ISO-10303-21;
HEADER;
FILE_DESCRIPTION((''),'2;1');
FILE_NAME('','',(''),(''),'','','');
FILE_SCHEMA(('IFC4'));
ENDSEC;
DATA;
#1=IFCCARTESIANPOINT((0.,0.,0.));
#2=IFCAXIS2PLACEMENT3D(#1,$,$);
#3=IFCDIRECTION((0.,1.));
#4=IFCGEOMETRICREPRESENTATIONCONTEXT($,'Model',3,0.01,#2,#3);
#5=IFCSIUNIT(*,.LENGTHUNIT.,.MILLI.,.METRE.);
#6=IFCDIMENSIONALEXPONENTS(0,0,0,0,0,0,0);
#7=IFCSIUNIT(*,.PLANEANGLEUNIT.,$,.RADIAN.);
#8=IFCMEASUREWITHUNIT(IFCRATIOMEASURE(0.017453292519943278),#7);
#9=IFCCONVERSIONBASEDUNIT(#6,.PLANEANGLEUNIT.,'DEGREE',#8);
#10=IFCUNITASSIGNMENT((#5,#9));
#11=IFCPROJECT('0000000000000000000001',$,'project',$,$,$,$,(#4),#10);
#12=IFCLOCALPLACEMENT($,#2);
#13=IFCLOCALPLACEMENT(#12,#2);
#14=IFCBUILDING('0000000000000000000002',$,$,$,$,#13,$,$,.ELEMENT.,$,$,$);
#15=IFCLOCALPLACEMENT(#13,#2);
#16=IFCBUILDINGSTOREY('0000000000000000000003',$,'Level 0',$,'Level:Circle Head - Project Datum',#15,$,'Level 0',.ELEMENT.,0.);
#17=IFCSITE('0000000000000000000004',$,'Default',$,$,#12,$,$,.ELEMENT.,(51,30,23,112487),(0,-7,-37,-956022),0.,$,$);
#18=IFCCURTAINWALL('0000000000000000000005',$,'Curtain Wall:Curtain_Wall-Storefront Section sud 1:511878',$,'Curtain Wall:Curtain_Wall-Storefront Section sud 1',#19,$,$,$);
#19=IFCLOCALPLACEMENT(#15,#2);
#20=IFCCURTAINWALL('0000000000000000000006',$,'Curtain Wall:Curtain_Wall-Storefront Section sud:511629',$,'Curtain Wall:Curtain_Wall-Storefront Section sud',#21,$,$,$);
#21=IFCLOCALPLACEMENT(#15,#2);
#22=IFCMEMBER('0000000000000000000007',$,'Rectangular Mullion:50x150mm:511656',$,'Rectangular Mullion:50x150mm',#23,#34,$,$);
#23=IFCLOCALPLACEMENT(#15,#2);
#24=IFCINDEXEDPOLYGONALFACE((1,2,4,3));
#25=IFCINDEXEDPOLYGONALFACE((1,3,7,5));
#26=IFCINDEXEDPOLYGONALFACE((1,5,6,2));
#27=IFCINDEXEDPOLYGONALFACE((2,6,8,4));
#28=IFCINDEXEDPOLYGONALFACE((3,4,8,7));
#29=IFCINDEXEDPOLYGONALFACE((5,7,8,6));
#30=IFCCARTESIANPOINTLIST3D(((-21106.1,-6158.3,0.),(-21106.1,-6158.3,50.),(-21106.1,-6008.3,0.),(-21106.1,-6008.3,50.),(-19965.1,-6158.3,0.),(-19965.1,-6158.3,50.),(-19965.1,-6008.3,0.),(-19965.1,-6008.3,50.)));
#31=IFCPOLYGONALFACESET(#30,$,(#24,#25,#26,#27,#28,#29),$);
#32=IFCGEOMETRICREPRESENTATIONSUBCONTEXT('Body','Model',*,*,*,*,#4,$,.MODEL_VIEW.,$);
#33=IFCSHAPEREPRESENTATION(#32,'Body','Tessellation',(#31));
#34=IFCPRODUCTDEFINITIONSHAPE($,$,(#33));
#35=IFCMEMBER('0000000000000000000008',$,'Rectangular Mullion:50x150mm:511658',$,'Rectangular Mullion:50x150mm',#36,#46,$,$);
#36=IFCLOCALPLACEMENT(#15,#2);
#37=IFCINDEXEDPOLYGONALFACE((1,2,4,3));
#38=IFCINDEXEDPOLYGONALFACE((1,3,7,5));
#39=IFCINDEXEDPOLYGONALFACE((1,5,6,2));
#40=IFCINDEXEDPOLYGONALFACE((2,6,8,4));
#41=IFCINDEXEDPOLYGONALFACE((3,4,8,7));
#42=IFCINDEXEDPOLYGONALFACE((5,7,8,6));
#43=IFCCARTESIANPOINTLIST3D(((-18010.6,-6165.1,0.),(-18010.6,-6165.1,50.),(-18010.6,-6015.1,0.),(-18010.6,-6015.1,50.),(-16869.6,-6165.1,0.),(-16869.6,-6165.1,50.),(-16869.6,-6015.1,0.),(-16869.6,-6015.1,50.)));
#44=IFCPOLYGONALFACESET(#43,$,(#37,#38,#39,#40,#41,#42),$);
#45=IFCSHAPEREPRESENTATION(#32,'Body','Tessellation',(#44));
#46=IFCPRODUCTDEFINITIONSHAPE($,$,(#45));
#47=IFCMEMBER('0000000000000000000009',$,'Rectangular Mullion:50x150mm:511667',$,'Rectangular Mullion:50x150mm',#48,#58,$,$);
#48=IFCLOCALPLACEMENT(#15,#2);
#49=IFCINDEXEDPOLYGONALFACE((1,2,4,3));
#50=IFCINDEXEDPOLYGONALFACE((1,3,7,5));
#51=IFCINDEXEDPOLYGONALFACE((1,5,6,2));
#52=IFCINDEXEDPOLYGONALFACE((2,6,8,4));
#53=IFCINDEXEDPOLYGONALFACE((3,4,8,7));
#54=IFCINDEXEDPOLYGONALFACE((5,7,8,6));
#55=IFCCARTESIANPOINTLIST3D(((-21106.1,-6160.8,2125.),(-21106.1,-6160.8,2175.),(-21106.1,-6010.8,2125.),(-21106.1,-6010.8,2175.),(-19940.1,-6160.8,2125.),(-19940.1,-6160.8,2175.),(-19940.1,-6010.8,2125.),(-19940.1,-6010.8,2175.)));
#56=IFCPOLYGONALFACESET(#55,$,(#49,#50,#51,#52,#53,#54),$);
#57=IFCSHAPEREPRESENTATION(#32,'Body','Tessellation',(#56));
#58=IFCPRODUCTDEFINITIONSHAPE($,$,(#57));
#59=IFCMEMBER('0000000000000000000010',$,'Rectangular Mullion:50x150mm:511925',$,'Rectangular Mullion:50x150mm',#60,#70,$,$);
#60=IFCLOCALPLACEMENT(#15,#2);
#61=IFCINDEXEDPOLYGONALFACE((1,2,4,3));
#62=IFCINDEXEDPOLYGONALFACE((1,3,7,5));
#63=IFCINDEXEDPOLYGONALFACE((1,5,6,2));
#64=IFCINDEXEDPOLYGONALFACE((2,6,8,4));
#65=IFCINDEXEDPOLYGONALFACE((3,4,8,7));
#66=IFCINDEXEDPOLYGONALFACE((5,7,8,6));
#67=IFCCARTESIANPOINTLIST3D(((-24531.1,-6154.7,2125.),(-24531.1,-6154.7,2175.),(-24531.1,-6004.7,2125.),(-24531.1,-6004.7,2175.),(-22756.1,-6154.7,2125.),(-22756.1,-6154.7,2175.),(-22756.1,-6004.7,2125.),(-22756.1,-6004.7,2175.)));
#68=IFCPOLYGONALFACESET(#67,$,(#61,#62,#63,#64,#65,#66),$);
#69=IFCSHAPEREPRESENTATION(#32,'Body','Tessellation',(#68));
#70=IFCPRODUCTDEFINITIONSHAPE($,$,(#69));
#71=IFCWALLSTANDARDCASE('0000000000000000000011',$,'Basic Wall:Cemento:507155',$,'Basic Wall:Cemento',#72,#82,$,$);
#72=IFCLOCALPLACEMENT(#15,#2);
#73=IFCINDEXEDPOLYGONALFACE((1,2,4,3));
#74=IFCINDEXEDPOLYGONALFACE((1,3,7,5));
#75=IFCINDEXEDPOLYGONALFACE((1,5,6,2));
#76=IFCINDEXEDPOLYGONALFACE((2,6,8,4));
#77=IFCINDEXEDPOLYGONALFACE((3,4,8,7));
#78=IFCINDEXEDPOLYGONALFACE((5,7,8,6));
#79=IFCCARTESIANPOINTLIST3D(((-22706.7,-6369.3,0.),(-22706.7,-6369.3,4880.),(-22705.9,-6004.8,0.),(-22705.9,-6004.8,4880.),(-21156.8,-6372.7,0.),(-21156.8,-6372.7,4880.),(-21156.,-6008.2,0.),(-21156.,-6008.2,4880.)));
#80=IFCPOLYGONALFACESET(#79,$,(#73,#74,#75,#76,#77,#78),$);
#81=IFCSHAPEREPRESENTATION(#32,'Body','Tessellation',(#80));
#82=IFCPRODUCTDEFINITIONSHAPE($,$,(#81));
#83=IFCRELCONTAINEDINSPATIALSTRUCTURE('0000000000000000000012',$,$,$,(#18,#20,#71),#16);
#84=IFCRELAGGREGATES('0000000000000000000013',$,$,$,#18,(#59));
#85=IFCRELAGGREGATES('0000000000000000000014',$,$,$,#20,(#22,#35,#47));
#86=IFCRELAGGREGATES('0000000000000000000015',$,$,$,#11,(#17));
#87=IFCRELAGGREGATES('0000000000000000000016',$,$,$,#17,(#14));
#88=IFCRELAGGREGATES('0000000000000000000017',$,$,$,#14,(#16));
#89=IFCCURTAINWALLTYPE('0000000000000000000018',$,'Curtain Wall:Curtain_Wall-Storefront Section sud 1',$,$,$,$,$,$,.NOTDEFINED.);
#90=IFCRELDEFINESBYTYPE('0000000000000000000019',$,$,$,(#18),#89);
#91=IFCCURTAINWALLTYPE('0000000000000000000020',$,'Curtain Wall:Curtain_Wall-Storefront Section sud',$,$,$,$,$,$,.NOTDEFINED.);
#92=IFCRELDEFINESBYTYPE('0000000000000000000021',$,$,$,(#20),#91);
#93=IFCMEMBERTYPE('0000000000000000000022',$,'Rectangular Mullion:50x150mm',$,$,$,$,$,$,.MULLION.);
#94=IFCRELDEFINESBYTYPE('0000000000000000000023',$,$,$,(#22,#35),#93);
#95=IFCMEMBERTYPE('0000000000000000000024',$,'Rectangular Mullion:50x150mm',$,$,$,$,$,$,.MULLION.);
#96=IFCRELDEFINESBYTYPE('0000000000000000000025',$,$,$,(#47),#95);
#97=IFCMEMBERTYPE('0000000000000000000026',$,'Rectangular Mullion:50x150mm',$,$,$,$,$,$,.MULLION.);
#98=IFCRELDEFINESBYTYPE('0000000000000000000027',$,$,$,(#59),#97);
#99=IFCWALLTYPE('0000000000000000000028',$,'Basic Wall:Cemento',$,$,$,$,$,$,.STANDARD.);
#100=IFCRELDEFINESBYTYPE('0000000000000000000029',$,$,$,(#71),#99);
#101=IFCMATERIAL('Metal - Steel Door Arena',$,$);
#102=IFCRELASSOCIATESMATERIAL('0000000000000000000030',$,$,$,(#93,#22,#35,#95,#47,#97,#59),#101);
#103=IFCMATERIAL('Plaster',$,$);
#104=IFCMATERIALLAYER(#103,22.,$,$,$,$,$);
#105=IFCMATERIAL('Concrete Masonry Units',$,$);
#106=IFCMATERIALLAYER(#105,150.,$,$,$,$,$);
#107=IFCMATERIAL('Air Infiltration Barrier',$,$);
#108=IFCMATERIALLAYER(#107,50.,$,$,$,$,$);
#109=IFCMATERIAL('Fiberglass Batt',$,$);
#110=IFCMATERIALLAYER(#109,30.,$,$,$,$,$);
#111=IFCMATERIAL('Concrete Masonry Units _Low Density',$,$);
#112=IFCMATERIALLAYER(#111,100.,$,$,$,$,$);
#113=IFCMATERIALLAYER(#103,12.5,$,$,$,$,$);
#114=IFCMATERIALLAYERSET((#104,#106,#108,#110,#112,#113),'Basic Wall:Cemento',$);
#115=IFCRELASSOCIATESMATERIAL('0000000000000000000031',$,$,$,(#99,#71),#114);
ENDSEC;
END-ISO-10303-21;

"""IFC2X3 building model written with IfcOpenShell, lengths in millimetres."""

from ifc_helpers import new_model, entity, si_unit, converted_unit, direction, frame, frame_2d, origin, origin_2d_with_axis, place, context, subcontext, project, spatial, rectangle, extrude, source, transform, mapped, material, layer, layer_set, layer_usage, type_object, type_shapes, element, aggregate, save


model = new_model("IFC2X3")

# Units and contexts
model_context = context("Model", 3, precision=0.01, world=origin(), true_north=direction((0.0, 1.0)))
body_context = subcontext(model_context, "Body", "Model", "MODEL_VIEW")
ifc_project = project(units=[si_unit("LENGTHUNIT", "METRE", prefix="MILLI"), converted_unit("PLANEANGLEUNIT", "DEGREE", entity("IfcRatioMeasure", 0.017453292519943278), si_unit("PLANEANGLEUNIT", "RADIAN"), dimensions=[0, 0, 0, 0, 0, 0, 0])], contexts=[model_context])

# Site, building, storey
site_placement = place(None, origin())
site = spatial("IfcSite", under=ifc_project, at=site_placement, Name="Default", CompositionType="ELEMENT", RefLatitude=(51, 30, 23, 112487), RefLongitude=(0, -7, -37, -956022), RefElevation=0.0)
building_placement = place(site_placement, origin())
building = spatial("IfcBuilding", under=site, at=building_placement, CompositionType="ELEMENT")
storey_placement = place(building_placement, origin())
storey = spatial("IfcBuildingStorey", under=building, at=storey_placement, Name="Level 0", ObjectType="Level:Circle Head - Project Datum", LongName="Level 0", CompositionType="ELEMENT", Elevation=0.0)

# Curtain wall
curtain_wall_type_1 = type_object("IfcCurtainWallType", Name="Curtain Wall:Curtain_Wall-Storefront Section sud 1", PredefinedType="NOTDEFINED")
curtain_wall_1_placement = place(storey_placement, origin())
curtain_wall_1 = element("IfcCurtainWall", 1, at=curtain_wall_1_placement, inside=storey, type_object=curtain_wall_type_1, Name="Curtain Wall:Curtain_Wall-Storefront Section sud 1:511878", ObjectType="Curtain Wall:Curtain_Wall-Storefront Section sud 1")
ifc_material_1 = material(Name="Metal - Steel Door Arena")

# Curtain wall
curtain_wall_type_2 = type_object("IfcCurtainWallType", Name="Curtain Wall:Curtain_Wall-Storefront Section sud", PredefinedType="NOTDEFINED")
curtain_wall_2_placement = place(storey_placement, origin())
curtain_wall_2 = element("IfcCurtainWall", 2, at=curtain_wall_2_placement, inside=storey, type_object=curtain_wall_type_2, Name="Curtain Wall:Curtain_Wall-Storefront Section sud:511629", ObjectType="Curtain Wall:Curtain_Wall-Storefront Section sud")

# Members
member_type_1 = type_object("IfcMemberType", Name="Rectangular Mullion:50x150mm", PredefinedType="MULLION", material=ifc_material_1)
shared_shape_1 = source(origin(), body_context, "Body", "SweptSolid", [
    extrude(rectangle(XDim=150.0, YDim=50.0, at=origin_2d_with_axis()), frame((-25.0, 0.0, -1141.0), z_axis=(0.0, 0.0, 1.0), x_axis=(0.0, -1.0, 0.0)), (0.0, 0.0, 1.0), 1141.0),
])
type_shapes(member_type_1, [shared_shape_1])
member_1_placement = place(curtain_wall_2_placement, frame((-21106.1, -6083.3, 0.0), z_axis=(-1.0, 0.0, 0.0), x_axis=(0.0, 0.0, -1.0)))
member_1 = element("IfcMember", 3, at=member_1_placement, type_object=member_type_1, material=ifc_material_1, Name="Rectangular Mullion:50x150mm:511656", ObjectType="Rectangular Mullion:50x150mm", context=body_context, shape_type="MappedRepresentation", body=[
    mapped(shared_shape_1, transform((0.0, 0.0, 0.0), scale=1.0)),
])
member_2_placement = place(curtain_wall_2_placement, frame((-18010.6, -6090.1, 0.0), z_axis=(-1.0, 0.0, 0.0), x_axis=(0.0, 0.0, -1.0)))
member_2 = element("IfcMember", 4, at=member_2_placement, type_object=member_type_1, material=ifc_material_1, Name="Rectangular Mullion:50x150mm:511658", ObjectType="Rectangular Mullion:50x150mm", context=body_context, shape_type="MappedRepresentation", body=[
    mapped(shared_shape_1, transform((0.0, 0.0, 0.0), scale=1.0)),
])
member_type_2 = type_object("IfcMemberType", Name="Rectangular Mullion:50x150mm", PredefinedType="MULLION", material=ifc_material_1)
shared_shape_2 = source(origin(), body_context, "Body", "SweptSolid", [
    extrude(rectangle(XDim=150.0, YDim=50.0, at=origin_2d_with_axis()), frame((0.0, 0.0, -1166.0), z_axis=(0.0, 0.0, 1.0), x_axis=(0.0, -1.0, 0.0)), (0.0, 0.0, 1.0), 1166.0),
])
type_shapes(member_type_2, [shared_shape_2])
member_3_placement = place(curtain_wall_2_placement, frame((-19940.1, -6085.8, 2150.0), z_axis=(1.0, 0.0, 0.0), x_axis=(0.0, 0.0, 1.0)))
member_3 = element("IfcMember", 5, at=member_3_placement, type_object=member_type_2, material=ifc_material_1, Name="Rectangular Mullion:50x150mm:511667", ObjectType="Rectangular Mullion:50x150mm", context=body_context, shape_type="MappedRepresentation", body=[
    mapped(shared_shape_2, transform((0.0, 0.0, 0.0), scale=1.0)),
])
member_type_3 = type_object("IfcMemberType", Name="Rectangular Mullion:50x150mm", PredefinedType="MULLION", material=ifc_material_1)
shared_shape_3 = source(origin(), body_context, "Body", "SweptSolid", [
    extrude(rectangle(XDim=150.0, YDim=50.0, at=origin_2d_with_axis()), frame((0.0, 0.0, -1775.0), z_axis=(0.0, 0.0, 1.0), x_axis=(0.0, -1.0, 0.0)), (0.0, 0.0, 1.0), 1775.0),
])
type_shapes(member_type_3, [shared_shape_3])
member_4_placement = place(curtain_wall_1_placement, frame((-22756.1, -6079.7, 2150.0), z_axis=(1.0, 0.0, 0.0), x_axis=(0.0, 0.0, 1.0)))
member_4 = element("IfcMember", 6, at=member_4_placement, type_object=member_type_3, material=ifc_material_1, Name="Rectangular Mullion:50x150mm:511925", ObjectType="Rectangular Mullion:50x150mm", context=body_context, shape_type="MappedRepresentation", body=[
    mapped(shared_shape_3, transform((0.0, 0.0, 0.0), scale=1.0)),
])
aggregate(curtain_wall_1, [member_4])

aggregate(curtain_wall_2, [member_1, member_2, member_3])

# Wall
ifc_material_2 = material(Name="Plaster")
ifc_layer_1 = layer(ifc_material_2, 22.0)
ifc_material_3 = material(Name="Concrete Masonry Units")
ifc_layer_2 = layer(ifc_material_3, 150.0)
ifc_material_4 = material(Name="Air Infiltration Barrier")
ifc_layer_3 = layer(ifc_material_4, 50.0)
ifc_material_5 = material(Name="Fiberglass Batt")
ifc_layer_4 = layer(ifc_material_5, 30.0)
ifc_material_6 = material(Name="Concrete Masonry Units _Low Density")
ifc_layer_5 = layer(ifc_material_6, 100.0)
ifc_layer_6 = layer(ifc_material_2, 12.5)
ifc_layer_set = layer_set([ifc_layer_1, ifc_layer_2, ifc_layer_3, ifc_layer_4, ifc_layer_5, ifc_layer_6], Name="Basic Wall:Cemento")
ifc_layer_usage = layer_usage(ifc_layer_set, "AXIS2", "NEGATIVE", 182.3)
wall_type = type_object("IfcWallType", Name="Basic Wall:Cemento", PredefinedType="STANDARD", material=ifc_layer_set)
wall_placement = place(storey_placement, frame((-21156.4, -6190.4, 0.0), z_axis=(0.0, 0.0, 1.0), x_axis=(-0.999998, 0.002199, 0.0)))
element("IfcWallStandardCase", 7, at=wall_placement, inside=storey, type_object=wall_type, material=ifc_layer_usage, Name="Basic Wall:Cemento:507155", ObjectType="Basic Wall:Cemento", context=body_context, shape_type="SweptSolid", body=[
    extrude(rectangle(XDim=1550.0, YDim=364.5, at=frame_2d((775.0, 0.0), x_axis=(-1.0, 0.0))), origin(), (0.0, 0.0, 1.0), 4880.0),
])

save(model, "model.ifc")
